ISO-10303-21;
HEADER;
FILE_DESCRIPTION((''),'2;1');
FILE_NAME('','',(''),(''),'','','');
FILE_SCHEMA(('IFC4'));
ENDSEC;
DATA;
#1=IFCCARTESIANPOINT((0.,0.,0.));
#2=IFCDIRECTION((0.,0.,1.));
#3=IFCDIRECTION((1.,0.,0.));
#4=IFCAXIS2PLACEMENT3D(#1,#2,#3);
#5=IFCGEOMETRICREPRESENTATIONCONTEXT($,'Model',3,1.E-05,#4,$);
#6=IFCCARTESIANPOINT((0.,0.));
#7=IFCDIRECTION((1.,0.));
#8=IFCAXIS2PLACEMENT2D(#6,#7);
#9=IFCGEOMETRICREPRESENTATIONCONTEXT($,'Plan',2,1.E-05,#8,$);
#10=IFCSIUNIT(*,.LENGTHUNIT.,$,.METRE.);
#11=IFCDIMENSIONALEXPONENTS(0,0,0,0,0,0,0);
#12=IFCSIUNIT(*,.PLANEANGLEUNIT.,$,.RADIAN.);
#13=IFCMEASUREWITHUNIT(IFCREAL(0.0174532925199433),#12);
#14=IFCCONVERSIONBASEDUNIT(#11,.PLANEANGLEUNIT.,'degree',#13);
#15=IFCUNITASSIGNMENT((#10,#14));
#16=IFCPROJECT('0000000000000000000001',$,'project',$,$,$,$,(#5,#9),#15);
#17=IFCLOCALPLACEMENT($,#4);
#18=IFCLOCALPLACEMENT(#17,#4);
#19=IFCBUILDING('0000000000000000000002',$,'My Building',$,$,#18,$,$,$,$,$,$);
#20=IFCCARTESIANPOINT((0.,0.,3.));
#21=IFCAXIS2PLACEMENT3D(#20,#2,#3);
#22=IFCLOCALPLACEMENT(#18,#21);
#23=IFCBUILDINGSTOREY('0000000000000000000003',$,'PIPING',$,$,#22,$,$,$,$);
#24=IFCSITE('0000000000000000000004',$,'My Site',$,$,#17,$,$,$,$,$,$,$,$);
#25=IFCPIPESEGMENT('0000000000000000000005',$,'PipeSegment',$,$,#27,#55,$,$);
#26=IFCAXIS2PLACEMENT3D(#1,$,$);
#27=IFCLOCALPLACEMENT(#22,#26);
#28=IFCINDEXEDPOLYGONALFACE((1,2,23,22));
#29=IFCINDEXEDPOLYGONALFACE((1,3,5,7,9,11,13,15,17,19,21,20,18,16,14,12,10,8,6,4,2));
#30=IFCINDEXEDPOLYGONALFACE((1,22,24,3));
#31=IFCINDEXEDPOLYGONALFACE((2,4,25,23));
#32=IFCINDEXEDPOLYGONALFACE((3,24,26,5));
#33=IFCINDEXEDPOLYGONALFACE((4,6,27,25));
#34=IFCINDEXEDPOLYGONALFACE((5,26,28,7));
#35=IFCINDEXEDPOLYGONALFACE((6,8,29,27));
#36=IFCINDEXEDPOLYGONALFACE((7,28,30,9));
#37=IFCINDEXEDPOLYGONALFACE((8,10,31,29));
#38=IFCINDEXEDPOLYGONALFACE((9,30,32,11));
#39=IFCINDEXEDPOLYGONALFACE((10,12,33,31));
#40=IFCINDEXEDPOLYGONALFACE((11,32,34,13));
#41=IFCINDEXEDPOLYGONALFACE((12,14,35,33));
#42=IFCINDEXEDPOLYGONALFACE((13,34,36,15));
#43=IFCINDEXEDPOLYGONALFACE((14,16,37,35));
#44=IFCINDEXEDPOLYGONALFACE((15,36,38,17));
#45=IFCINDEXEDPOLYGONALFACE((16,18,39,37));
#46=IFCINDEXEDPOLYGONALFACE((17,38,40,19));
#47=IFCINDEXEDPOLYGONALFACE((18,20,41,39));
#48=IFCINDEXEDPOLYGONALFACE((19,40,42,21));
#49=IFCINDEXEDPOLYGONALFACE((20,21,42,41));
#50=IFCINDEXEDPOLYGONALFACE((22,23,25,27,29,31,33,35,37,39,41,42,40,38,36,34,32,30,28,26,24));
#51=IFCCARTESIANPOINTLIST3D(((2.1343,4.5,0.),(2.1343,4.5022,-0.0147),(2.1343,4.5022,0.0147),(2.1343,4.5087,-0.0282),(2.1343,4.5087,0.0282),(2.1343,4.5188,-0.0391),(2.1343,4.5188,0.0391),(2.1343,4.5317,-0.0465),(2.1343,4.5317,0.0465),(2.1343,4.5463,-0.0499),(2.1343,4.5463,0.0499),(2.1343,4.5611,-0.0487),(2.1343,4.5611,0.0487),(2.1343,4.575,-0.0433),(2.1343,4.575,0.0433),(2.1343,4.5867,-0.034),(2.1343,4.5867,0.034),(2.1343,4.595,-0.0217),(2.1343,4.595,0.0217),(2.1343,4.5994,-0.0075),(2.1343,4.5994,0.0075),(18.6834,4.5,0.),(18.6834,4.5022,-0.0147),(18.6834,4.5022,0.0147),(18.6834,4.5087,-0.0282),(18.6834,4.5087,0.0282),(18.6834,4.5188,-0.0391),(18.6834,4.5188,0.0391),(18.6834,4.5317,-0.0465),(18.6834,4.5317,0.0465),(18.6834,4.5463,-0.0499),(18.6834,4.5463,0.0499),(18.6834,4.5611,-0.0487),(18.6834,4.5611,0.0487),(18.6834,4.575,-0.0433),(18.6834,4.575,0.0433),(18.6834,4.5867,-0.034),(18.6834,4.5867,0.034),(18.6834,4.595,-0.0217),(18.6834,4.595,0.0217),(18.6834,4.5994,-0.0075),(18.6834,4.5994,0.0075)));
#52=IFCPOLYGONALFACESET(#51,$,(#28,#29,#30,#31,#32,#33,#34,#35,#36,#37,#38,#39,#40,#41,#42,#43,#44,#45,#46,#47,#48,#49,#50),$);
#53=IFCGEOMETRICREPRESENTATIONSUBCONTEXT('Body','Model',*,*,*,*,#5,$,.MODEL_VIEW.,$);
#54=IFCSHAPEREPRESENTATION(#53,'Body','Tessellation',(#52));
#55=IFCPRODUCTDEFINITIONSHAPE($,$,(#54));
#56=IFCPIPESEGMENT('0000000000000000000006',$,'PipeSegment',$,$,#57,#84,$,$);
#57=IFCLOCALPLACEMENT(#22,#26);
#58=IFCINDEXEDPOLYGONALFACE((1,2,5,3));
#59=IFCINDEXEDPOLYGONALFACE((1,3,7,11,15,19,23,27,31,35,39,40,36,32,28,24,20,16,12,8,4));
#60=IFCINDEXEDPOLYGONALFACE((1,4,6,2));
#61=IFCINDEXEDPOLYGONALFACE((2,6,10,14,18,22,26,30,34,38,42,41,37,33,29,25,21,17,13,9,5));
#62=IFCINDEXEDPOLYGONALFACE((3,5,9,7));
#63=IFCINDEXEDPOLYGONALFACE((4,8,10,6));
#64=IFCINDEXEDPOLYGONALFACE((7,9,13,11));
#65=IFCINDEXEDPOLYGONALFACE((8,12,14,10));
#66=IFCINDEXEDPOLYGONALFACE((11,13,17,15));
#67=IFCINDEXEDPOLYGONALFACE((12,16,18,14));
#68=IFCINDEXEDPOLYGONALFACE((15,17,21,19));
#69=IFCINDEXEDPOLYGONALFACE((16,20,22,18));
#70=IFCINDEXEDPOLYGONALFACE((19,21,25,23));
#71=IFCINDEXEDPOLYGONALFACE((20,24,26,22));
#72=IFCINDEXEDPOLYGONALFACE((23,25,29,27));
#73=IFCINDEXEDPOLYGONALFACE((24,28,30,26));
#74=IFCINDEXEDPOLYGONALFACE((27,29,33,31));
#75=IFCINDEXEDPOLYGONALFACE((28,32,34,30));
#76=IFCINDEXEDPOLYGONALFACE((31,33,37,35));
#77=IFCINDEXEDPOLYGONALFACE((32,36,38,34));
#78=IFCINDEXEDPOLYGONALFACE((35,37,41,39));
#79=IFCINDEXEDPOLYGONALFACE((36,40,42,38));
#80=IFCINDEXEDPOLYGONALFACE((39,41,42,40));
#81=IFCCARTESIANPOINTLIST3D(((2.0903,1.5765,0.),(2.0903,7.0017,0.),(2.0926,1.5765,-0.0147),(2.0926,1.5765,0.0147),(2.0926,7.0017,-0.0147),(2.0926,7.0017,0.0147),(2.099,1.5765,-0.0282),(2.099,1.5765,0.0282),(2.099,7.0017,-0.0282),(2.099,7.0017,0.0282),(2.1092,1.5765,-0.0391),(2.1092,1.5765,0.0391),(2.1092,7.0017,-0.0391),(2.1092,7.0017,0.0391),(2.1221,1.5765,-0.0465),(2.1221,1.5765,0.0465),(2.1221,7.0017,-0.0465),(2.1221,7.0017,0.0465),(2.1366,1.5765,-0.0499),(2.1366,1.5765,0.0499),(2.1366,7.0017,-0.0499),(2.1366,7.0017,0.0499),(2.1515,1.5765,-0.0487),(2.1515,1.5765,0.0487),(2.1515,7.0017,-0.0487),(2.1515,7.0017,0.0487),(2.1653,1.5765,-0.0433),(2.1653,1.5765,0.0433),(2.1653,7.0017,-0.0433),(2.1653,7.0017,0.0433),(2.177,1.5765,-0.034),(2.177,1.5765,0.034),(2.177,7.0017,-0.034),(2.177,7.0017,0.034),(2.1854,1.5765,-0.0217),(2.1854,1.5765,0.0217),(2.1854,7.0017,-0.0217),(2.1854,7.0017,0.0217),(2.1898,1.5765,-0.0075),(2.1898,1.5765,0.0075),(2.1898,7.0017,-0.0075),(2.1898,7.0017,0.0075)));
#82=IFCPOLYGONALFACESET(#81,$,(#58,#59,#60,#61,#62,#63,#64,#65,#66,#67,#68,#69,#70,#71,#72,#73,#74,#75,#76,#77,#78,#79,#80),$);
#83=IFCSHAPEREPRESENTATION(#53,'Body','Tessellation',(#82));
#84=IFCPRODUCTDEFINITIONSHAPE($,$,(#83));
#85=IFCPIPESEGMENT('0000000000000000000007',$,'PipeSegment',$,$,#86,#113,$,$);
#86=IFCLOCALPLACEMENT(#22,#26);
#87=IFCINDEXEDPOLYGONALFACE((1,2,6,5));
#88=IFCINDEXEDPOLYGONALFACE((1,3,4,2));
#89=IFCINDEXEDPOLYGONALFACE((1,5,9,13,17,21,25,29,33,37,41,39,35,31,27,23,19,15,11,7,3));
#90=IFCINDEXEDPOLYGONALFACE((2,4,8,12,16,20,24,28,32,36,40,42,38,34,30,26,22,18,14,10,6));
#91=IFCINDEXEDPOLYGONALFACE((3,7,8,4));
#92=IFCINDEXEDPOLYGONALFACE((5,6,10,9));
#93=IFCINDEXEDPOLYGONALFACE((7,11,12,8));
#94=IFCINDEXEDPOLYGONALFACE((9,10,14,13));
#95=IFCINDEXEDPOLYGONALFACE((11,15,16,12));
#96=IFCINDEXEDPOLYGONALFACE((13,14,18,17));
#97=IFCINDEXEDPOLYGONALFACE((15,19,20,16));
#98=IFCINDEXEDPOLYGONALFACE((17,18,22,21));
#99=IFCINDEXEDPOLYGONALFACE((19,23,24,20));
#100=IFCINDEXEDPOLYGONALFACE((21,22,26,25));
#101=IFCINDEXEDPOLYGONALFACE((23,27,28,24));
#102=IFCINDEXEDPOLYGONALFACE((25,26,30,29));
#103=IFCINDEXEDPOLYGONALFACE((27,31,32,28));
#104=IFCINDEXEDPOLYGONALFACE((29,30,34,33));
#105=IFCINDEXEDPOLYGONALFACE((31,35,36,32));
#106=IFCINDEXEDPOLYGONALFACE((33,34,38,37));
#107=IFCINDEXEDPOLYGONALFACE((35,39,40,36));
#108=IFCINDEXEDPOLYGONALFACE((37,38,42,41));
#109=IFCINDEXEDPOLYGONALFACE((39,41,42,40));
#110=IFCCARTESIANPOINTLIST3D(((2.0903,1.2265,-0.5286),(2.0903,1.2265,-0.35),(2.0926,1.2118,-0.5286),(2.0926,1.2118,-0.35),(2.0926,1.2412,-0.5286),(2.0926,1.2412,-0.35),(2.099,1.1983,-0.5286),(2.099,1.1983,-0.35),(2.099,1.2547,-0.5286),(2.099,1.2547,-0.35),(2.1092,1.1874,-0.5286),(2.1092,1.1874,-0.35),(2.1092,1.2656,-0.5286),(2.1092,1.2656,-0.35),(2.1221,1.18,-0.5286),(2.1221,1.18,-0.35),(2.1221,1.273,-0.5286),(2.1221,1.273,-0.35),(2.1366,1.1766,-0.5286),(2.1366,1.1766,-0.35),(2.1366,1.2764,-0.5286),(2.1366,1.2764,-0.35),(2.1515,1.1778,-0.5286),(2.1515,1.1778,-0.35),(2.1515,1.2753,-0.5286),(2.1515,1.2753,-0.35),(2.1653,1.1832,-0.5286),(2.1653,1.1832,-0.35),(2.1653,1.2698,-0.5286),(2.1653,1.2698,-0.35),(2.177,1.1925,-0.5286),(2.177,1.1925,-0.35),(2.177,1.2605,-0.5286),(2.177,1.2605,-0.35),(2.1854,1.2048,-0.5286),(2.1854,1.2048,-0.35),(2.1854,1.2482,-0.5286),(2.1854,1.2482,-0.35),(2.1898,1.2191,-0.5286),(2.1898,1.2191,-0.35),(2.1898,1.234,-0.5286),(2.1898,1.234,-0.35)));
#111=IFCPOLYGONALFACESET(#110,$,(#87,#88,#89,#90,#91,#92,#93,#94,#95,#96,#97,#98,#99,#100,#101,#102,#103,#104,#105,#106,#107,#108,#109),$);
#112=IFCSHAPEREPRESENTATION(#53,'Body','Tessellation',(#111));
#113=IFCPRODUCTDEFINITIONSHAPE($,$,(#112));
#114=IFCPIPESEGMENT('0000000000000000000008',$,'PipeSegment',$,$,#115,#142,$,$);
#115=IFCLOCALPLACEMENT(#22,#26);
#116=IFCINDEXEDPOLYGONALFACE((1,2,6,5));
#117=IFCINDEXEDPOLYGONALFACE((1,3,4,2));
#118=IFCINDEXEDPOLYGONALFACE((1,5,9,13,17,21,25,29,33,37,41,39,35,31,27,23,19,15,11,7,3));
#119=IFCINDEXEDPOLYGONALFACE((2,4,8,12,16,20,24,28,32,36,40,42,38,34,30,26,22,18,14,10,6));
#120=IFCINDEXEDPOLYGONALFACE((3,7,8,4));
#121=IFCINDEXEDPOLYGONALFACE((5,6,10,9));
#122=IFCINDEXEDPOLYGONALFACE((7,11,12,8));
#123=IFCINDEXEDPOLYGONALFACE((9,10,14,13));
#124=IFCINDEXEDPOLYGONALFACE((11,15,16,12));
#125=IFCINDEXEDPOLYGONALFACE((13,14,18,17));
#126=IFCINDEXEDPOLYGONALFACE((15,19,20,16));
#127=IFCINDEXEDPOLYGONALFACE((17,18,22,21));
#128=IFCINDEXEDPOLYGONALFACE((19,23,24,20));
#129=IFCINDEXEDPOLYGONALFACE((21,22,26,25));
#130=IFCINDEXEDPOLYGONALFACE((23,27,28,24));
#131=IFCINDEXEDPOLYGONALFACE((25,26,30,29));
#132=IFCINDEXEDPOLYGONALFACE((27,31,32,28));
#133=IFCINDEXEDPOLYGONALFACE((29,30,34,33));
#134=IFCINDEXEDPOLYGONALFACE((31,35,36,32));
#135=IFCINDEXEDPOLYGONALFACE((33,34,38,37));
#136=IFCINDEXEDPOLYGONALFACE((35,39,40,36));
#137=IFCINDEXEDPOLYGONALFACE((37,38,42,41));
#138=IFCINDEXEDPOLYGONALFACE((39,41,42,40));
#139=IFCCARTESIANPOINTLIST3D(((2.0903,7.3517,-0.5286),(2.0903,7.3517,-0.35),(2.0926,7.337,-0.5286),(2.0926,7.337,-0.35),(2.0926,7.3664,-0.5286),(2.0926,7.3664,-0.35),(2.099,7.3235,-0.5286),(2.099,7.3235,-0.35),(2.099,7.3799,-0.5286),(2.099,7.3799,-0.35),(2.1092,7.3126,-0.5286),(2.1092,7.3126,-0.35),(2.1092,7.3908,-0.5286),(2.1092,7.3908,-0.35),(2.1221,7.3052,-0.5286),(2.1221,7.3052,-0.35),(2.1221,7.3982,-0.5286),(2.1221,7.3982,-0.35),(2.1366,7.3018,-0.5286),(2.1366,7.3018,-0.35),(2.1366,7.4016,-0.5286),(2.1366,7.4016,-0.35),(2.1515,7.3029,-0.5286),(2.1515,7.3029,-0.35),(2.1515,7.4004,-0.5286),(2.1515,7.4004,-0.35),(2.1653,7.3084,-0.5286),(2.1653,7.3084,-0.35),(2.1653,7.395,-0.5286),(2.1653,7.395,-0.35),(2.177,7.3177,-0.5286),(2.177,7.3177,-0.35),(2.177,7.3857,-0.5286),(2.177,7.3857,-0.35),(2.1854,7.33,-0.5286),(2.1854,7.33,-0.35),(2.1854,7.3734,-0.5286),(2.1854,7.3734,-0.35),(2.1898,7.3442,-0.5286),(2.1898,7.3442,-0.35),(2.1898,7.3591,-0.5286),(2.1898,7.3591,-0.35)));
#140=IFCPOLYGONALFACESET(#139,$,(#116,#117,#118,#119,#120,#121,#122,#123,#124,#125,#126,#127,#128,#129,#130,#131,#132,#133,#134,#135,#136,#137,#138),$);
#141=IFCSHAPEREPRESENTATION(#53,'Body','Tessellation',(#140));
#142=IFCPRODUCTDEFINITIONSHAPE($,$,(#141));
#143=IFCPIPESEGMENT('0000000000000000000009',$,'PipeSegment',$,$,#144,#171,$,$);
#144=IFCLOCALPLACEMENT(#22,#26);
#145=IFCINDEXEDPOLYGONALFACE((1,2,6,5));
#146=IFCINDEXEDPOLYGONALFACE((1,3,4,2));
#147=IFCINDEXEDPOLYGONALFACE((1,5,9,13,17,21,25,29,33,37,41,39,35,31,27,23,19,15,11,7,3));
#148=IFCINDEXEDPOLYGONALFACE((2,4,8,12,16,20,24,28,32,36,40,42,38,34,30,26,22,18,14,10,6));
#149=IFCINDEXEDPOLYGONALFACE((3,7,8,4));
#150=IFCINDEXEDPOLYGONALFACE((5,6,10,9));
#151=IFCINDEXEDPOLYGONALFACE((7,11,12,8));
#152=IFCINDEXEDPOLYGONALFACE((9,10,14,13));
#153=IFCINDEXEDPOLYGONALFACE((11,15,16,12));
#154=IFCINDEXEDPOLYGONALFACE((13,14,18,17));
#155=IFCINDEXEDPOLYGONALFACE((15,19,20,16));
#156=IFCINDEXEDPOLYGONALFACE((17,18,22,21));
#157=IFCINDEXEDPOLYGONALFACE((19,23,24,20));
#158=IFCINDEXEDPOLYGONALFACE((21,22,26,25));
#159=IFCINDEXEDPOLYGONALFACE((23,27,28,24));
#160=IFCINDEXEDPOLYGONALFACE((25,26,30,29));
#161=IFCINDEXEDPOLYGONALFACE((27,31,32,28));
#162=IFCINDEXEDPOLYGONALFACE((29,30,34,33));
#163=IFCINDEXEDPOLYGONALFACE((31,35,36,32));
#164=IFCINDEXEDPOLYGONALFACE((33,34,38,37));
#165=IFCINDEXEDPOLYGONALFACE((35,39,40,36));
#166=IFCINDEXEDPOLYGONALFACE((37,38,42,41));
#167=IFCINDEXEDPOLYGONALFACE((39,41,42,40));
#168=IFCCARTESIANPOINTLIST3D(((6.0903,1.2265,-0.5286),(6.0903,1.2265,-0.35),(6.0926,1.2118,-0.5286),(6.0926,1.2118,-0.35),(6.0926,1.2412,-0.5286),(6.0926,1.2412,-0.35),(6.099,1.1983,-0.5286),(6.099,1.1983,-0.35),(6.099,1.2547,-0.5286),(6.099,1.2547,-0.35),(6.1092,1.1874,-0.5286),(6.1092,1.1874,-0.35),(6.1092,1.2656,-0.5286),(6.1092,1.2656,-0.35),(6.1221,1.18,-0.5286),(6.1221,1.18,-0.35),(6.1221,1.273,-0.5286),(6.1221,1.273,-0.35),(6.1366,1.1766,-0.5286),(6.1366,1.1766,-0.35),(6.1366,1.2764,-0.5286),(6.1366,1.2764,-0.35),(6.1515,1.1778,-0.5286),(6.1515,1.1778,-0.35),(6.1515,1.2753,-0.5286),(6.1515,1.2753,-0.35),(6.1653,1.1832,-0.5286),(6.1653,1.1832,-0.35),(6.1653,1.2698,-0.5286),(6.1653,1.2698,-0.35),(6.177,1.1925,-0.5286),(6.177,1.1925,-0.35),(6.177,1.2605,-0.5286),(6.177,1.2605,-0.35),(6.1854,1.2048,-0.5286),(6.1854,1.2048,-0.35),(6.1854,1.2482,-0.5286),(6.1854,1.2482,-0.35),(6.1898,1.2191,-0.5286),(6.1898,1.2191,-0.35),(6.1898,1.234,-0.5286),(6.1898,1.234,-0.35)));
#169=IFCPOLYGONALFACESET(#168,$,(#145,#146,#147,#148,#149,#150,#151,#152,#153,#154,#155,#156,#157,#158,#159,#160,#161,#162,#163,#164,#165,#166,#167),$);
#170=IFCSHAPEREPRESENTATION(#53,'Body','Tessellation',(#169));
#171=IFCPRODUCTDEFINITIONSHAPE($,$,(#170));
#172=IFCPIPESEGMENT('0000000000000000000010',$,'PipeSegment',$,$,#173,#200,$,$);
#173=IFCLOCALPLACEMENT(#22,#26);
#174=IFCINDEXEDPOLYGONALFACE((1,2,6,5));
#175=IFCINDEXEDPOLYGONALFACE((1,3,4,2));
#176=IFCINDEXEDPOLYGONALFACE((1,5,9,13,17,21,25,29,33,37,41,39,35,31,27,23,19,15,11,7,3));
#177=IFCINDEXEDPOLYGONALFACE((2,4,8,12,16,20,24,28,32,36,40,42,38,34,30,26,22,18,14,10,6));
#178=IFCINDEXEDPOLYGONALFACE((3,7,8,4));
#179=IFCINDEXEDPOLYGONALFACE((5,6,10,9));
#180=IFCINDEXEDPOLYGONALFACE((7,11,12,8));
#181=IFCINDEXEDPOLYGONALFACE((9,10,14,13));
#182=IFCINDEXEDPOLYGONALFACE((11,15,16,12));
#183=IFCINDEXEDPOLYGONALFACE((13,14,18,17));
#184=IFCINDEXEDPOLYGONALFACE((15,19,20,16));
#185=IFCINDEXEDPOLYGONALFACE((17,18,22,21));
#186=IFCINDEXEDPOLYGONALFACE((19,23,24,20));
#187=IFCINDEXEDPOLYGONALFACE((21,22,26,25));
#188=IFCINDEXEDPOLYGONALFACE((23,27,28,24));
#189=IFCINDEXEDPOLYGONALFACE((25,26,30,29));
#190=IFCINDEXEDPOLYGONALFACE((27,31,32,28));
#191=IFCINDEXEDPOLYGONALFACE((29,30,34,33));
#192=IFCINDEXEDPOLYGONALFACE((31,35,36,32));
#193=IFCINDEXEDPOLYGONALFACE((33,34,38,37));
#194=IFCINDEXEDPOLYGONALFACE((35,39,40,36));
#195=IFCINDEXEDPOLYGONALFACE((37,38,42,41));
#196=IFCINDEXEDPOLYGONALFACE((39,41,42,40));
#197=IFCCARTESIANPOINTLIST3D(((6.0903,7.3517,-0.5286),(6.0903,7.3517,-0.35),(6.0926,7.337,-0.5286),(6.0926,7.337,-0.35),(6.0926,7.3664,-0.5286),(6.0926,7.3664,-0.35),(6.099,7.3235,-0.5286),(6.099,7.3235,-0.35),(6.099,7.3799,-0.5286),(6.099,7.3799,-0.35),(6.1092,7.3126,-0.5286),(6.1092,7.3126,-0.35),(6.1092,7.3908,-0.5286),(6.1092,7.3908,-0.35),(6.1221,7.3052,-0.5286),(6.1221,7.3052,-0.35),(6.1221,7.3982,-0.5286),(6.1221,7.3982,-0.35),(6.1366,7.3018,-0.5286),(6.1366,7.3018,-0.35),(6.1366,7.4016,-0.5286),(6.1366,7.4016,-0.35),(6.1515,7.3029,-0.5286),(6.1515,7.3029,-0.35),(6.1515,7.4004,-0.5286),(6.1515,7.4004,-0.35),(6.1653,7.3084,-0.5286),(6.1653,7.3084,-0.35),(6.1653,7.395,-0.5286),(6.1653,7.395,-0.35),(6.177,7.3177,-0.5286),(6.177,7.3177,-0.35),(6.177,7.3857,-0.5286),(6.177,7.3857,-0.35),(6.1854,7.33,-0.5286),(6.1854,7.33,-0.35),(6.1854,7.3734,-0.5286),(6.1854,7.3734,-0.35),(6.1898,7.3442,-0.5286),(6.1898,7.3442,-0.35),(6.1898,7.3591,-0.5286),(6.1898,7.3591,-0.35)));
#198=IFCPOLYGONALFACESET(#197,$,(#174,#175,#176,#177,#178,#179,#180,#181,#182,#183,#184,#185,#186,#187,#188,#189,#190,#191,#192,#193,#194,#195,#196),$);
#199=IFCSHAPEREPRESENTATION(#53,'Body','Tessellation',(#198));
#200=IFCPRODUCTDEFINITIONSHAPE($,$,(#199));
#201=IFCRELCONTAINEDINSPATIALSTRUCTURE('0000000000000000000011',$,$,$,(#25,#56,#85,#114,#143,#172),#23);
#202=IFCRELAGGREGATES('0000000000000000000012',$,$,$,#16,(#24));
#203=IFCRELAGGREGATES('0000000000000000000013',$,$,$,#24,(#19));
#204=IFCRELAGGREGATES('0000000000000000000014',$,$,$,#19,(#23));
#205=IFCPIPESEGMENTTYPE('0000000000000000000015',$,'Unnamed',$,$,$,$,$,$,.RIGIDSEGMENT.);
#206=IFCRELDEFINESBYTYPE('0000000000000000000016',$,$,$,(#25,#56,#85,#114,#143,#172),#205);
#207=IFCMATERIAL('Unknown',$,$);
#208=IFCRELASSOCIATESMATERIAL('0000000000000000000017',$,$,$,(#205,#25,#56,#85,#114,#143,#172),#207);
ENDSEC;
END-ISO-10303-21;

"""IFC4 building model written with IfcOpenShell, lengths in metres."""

from ifc_helpers import new_model, entity, si_unit, converted_unit, frame, origin_with_axes, origin_2d_with_axis, place, context, subcontext, project, spatial, circle, extrude, material, material_profile, profile_set, profile_usage, type_object, element, save


model = new_model("IFC4")

# Units and contexts
model_context = context("Model", 3, precision=1e-05, world=origin_with_axes())
plan_context = context("Plan", 2, precision=1e-05, world=origin_2d_with_axis())
body_context = subcontext(model_context, "Body", "Model", "MODEL_VIEW")
ifc_project = project(units=[si_unit("LENGTHUNIT", "METRE"), converted_unit("PLANEANGLEUNIT", "degree", entity("IfcReal", 0.0174532925199433), si_unit("PLANEANGLEUNIT", "RADIAN"), dimensions=[0, 0, 0, 0, 0, 0, 0])], contexts=[model_context, plan_context])

# Site, building, storey
site_placement = place(None, origin_with_axes())
site = spatial("IfcSite", under=ifc_project, at=site_placement, Name="My Site")
building_placement = place(site_placement, origin_with_axes())
building = spatial("IfcBuilding", under=site, at=building_placement, Name="My Building")
storey_placement = place(building_placement, frame((0.0, 0.0, 3.0), z_axis=(0.0, 0.0, 1.0), x_axis=(1.0, 0.0, 0.0)))
storey = spatial("IfcBuildingStorey", under=building, at=storey_placement, Name="PIPING")

# Pipe segments
ifc_material = material(Name="Unknown")
ifc_material_profile = material_profile(ifc_material, circle(Radius=0.05))
ifc_profile_set = profile_set([ifc_material_profile])
ifc_profile_usage_1 = profile_usage(ifc_profile_set, cardinal=5)
pipe_segment_type = type_object("IfcPipeSegmentType", Name="Unnamed", PredefinedType="RIGIDSEGMENT", material=ifc_profile_set)
pipe_segment_1_placement = place(storey_placement, frame((18.6834, 4.55, 0.0), z_axis=(-1.0, 0.0, 0.0), x_axis=(0.0, -1.0, 0.0)))
element("IfcPipeSegment", 1, at=pipe_segment_1_placement, inside=storey, type_object=pipe_segment_type, material=ifc_profile_usage_1, Name="PipeSegment", context=body_context, shape_type="SweptSolid", body=[
    extrude(circle(Radius=0.05), origin_with_axes(), (0.0, 0.0, 1.0), 16.5491),
])
ifc_profile_usage_2 = profile_usage(ifc_profile_set, cardinal=5)
pipe_segment_2_placement = place(storey_placement, frame((2.1403, 1.5765, 0.0), z_axis=(0.0, 1.0, 0.0), x_axis=(-1.0, 0.0, 0.0)))
element("IfcPipeSegment", 2, at=pipe_segment_2_placement, inside=storey, type_object=pipe_segment_type, material=ifc_profile_usage_2, Name="PipeSegment", context=body_context, shape_type="SweptSolid", body=[
    extrude(circle(Radius=0.05), origin_with_axes(), (0.0, 0.0, 1.0), 5.4252),
])
ifc_profile_usage_3 = profile_usage(ifc_profile_set, cardinal=5)
pipe_segment_3_placement = place(storey_placement, frame((2.1403, 1.2265, -0.35), z_axis=(0.0, 0.0, -1.0), x_axis=(-1.0, 0.0, 0.0)))
element("IfcPipeSegment", 3, at=pipe_segment_3_placement, inside=storey, type_object=pipe_segment_type, material=ifc_profile_usage_3, Name="PipeSegment", context=body_context, shape_type="SweptSolid", body=[
    extrude(circle(Radius=0.05), origin_with_axes(), (0.0, 0.0, 1.0), 0.1786),
])
ifc_profile_usage_4 = profile_usage(ifc_profile_set, cardinal=5)
pipe_segment_4_placement = place(storey_placement, frame((2.1403, 7.3517, -0.35), z_axis=(0.0, 0.0, -1.0), x_axis=(-1.0, 0.0, 0.0)))
element("IfcPipeSegment", 4, at=pipe_segment_4_placement, inside=storey, type_object=pipe_segment_type, material=ifc_profile_usage_4, Name="PipeSegment", context=body_context, shape_type="SweptSolid", body=[
    extrude(circle(Radius=0.05), origin_with_axes(), (0.0, 0.0, 1.0), 0.1786),
])
ifc_profile_usage_5 = profile_usage(ifc_profile_set, cardinal=5)
pipe_segment_5_placement = place(storey_placement, frame((6.1403, 1.2265, -0.35), z_axis=(0.0, 0.0, -1.0), x_axis=(-1.0, 0.0, 0.0)))
element("IfcPipeSegment", 5, at=pipe_segment_5_placement, inside=storey, type_object=pipe_segment_type, material=ifc_profile_usage_5, Name="PipeSegment", context=body_context, shape_type="SweptSolid", body=[
    extrude(circle(Radius=0.05), origin_with_axes(), (0.0, 0.0, 1.0), 0.1786),
])
ifc_profile_usage_6 = profile_usage(ifc_profile_set, cardinal=5)
pipe_segment_6_placement = place(storey_placement, frame((6.1403, 7.3517, -0.35), z_axis=(0.0, 0.0, -1.0), x_axis=(-1.0, 0.0, 0.0)))
element("IfcPipeSegment", 6, at=pipe_segment_6_placement, inside=storey, type_object=pipe_segment_type, material=ifc_profile_usage_6, Name="PipeSegment", context=body_context, shape_type="SweptSolid", body=[
    extrude(circle(Radius=0.05), origin_with_axes(), (0.0, 0.0, 1.0), 0.1786),
])

save(model, "model.ifc")
